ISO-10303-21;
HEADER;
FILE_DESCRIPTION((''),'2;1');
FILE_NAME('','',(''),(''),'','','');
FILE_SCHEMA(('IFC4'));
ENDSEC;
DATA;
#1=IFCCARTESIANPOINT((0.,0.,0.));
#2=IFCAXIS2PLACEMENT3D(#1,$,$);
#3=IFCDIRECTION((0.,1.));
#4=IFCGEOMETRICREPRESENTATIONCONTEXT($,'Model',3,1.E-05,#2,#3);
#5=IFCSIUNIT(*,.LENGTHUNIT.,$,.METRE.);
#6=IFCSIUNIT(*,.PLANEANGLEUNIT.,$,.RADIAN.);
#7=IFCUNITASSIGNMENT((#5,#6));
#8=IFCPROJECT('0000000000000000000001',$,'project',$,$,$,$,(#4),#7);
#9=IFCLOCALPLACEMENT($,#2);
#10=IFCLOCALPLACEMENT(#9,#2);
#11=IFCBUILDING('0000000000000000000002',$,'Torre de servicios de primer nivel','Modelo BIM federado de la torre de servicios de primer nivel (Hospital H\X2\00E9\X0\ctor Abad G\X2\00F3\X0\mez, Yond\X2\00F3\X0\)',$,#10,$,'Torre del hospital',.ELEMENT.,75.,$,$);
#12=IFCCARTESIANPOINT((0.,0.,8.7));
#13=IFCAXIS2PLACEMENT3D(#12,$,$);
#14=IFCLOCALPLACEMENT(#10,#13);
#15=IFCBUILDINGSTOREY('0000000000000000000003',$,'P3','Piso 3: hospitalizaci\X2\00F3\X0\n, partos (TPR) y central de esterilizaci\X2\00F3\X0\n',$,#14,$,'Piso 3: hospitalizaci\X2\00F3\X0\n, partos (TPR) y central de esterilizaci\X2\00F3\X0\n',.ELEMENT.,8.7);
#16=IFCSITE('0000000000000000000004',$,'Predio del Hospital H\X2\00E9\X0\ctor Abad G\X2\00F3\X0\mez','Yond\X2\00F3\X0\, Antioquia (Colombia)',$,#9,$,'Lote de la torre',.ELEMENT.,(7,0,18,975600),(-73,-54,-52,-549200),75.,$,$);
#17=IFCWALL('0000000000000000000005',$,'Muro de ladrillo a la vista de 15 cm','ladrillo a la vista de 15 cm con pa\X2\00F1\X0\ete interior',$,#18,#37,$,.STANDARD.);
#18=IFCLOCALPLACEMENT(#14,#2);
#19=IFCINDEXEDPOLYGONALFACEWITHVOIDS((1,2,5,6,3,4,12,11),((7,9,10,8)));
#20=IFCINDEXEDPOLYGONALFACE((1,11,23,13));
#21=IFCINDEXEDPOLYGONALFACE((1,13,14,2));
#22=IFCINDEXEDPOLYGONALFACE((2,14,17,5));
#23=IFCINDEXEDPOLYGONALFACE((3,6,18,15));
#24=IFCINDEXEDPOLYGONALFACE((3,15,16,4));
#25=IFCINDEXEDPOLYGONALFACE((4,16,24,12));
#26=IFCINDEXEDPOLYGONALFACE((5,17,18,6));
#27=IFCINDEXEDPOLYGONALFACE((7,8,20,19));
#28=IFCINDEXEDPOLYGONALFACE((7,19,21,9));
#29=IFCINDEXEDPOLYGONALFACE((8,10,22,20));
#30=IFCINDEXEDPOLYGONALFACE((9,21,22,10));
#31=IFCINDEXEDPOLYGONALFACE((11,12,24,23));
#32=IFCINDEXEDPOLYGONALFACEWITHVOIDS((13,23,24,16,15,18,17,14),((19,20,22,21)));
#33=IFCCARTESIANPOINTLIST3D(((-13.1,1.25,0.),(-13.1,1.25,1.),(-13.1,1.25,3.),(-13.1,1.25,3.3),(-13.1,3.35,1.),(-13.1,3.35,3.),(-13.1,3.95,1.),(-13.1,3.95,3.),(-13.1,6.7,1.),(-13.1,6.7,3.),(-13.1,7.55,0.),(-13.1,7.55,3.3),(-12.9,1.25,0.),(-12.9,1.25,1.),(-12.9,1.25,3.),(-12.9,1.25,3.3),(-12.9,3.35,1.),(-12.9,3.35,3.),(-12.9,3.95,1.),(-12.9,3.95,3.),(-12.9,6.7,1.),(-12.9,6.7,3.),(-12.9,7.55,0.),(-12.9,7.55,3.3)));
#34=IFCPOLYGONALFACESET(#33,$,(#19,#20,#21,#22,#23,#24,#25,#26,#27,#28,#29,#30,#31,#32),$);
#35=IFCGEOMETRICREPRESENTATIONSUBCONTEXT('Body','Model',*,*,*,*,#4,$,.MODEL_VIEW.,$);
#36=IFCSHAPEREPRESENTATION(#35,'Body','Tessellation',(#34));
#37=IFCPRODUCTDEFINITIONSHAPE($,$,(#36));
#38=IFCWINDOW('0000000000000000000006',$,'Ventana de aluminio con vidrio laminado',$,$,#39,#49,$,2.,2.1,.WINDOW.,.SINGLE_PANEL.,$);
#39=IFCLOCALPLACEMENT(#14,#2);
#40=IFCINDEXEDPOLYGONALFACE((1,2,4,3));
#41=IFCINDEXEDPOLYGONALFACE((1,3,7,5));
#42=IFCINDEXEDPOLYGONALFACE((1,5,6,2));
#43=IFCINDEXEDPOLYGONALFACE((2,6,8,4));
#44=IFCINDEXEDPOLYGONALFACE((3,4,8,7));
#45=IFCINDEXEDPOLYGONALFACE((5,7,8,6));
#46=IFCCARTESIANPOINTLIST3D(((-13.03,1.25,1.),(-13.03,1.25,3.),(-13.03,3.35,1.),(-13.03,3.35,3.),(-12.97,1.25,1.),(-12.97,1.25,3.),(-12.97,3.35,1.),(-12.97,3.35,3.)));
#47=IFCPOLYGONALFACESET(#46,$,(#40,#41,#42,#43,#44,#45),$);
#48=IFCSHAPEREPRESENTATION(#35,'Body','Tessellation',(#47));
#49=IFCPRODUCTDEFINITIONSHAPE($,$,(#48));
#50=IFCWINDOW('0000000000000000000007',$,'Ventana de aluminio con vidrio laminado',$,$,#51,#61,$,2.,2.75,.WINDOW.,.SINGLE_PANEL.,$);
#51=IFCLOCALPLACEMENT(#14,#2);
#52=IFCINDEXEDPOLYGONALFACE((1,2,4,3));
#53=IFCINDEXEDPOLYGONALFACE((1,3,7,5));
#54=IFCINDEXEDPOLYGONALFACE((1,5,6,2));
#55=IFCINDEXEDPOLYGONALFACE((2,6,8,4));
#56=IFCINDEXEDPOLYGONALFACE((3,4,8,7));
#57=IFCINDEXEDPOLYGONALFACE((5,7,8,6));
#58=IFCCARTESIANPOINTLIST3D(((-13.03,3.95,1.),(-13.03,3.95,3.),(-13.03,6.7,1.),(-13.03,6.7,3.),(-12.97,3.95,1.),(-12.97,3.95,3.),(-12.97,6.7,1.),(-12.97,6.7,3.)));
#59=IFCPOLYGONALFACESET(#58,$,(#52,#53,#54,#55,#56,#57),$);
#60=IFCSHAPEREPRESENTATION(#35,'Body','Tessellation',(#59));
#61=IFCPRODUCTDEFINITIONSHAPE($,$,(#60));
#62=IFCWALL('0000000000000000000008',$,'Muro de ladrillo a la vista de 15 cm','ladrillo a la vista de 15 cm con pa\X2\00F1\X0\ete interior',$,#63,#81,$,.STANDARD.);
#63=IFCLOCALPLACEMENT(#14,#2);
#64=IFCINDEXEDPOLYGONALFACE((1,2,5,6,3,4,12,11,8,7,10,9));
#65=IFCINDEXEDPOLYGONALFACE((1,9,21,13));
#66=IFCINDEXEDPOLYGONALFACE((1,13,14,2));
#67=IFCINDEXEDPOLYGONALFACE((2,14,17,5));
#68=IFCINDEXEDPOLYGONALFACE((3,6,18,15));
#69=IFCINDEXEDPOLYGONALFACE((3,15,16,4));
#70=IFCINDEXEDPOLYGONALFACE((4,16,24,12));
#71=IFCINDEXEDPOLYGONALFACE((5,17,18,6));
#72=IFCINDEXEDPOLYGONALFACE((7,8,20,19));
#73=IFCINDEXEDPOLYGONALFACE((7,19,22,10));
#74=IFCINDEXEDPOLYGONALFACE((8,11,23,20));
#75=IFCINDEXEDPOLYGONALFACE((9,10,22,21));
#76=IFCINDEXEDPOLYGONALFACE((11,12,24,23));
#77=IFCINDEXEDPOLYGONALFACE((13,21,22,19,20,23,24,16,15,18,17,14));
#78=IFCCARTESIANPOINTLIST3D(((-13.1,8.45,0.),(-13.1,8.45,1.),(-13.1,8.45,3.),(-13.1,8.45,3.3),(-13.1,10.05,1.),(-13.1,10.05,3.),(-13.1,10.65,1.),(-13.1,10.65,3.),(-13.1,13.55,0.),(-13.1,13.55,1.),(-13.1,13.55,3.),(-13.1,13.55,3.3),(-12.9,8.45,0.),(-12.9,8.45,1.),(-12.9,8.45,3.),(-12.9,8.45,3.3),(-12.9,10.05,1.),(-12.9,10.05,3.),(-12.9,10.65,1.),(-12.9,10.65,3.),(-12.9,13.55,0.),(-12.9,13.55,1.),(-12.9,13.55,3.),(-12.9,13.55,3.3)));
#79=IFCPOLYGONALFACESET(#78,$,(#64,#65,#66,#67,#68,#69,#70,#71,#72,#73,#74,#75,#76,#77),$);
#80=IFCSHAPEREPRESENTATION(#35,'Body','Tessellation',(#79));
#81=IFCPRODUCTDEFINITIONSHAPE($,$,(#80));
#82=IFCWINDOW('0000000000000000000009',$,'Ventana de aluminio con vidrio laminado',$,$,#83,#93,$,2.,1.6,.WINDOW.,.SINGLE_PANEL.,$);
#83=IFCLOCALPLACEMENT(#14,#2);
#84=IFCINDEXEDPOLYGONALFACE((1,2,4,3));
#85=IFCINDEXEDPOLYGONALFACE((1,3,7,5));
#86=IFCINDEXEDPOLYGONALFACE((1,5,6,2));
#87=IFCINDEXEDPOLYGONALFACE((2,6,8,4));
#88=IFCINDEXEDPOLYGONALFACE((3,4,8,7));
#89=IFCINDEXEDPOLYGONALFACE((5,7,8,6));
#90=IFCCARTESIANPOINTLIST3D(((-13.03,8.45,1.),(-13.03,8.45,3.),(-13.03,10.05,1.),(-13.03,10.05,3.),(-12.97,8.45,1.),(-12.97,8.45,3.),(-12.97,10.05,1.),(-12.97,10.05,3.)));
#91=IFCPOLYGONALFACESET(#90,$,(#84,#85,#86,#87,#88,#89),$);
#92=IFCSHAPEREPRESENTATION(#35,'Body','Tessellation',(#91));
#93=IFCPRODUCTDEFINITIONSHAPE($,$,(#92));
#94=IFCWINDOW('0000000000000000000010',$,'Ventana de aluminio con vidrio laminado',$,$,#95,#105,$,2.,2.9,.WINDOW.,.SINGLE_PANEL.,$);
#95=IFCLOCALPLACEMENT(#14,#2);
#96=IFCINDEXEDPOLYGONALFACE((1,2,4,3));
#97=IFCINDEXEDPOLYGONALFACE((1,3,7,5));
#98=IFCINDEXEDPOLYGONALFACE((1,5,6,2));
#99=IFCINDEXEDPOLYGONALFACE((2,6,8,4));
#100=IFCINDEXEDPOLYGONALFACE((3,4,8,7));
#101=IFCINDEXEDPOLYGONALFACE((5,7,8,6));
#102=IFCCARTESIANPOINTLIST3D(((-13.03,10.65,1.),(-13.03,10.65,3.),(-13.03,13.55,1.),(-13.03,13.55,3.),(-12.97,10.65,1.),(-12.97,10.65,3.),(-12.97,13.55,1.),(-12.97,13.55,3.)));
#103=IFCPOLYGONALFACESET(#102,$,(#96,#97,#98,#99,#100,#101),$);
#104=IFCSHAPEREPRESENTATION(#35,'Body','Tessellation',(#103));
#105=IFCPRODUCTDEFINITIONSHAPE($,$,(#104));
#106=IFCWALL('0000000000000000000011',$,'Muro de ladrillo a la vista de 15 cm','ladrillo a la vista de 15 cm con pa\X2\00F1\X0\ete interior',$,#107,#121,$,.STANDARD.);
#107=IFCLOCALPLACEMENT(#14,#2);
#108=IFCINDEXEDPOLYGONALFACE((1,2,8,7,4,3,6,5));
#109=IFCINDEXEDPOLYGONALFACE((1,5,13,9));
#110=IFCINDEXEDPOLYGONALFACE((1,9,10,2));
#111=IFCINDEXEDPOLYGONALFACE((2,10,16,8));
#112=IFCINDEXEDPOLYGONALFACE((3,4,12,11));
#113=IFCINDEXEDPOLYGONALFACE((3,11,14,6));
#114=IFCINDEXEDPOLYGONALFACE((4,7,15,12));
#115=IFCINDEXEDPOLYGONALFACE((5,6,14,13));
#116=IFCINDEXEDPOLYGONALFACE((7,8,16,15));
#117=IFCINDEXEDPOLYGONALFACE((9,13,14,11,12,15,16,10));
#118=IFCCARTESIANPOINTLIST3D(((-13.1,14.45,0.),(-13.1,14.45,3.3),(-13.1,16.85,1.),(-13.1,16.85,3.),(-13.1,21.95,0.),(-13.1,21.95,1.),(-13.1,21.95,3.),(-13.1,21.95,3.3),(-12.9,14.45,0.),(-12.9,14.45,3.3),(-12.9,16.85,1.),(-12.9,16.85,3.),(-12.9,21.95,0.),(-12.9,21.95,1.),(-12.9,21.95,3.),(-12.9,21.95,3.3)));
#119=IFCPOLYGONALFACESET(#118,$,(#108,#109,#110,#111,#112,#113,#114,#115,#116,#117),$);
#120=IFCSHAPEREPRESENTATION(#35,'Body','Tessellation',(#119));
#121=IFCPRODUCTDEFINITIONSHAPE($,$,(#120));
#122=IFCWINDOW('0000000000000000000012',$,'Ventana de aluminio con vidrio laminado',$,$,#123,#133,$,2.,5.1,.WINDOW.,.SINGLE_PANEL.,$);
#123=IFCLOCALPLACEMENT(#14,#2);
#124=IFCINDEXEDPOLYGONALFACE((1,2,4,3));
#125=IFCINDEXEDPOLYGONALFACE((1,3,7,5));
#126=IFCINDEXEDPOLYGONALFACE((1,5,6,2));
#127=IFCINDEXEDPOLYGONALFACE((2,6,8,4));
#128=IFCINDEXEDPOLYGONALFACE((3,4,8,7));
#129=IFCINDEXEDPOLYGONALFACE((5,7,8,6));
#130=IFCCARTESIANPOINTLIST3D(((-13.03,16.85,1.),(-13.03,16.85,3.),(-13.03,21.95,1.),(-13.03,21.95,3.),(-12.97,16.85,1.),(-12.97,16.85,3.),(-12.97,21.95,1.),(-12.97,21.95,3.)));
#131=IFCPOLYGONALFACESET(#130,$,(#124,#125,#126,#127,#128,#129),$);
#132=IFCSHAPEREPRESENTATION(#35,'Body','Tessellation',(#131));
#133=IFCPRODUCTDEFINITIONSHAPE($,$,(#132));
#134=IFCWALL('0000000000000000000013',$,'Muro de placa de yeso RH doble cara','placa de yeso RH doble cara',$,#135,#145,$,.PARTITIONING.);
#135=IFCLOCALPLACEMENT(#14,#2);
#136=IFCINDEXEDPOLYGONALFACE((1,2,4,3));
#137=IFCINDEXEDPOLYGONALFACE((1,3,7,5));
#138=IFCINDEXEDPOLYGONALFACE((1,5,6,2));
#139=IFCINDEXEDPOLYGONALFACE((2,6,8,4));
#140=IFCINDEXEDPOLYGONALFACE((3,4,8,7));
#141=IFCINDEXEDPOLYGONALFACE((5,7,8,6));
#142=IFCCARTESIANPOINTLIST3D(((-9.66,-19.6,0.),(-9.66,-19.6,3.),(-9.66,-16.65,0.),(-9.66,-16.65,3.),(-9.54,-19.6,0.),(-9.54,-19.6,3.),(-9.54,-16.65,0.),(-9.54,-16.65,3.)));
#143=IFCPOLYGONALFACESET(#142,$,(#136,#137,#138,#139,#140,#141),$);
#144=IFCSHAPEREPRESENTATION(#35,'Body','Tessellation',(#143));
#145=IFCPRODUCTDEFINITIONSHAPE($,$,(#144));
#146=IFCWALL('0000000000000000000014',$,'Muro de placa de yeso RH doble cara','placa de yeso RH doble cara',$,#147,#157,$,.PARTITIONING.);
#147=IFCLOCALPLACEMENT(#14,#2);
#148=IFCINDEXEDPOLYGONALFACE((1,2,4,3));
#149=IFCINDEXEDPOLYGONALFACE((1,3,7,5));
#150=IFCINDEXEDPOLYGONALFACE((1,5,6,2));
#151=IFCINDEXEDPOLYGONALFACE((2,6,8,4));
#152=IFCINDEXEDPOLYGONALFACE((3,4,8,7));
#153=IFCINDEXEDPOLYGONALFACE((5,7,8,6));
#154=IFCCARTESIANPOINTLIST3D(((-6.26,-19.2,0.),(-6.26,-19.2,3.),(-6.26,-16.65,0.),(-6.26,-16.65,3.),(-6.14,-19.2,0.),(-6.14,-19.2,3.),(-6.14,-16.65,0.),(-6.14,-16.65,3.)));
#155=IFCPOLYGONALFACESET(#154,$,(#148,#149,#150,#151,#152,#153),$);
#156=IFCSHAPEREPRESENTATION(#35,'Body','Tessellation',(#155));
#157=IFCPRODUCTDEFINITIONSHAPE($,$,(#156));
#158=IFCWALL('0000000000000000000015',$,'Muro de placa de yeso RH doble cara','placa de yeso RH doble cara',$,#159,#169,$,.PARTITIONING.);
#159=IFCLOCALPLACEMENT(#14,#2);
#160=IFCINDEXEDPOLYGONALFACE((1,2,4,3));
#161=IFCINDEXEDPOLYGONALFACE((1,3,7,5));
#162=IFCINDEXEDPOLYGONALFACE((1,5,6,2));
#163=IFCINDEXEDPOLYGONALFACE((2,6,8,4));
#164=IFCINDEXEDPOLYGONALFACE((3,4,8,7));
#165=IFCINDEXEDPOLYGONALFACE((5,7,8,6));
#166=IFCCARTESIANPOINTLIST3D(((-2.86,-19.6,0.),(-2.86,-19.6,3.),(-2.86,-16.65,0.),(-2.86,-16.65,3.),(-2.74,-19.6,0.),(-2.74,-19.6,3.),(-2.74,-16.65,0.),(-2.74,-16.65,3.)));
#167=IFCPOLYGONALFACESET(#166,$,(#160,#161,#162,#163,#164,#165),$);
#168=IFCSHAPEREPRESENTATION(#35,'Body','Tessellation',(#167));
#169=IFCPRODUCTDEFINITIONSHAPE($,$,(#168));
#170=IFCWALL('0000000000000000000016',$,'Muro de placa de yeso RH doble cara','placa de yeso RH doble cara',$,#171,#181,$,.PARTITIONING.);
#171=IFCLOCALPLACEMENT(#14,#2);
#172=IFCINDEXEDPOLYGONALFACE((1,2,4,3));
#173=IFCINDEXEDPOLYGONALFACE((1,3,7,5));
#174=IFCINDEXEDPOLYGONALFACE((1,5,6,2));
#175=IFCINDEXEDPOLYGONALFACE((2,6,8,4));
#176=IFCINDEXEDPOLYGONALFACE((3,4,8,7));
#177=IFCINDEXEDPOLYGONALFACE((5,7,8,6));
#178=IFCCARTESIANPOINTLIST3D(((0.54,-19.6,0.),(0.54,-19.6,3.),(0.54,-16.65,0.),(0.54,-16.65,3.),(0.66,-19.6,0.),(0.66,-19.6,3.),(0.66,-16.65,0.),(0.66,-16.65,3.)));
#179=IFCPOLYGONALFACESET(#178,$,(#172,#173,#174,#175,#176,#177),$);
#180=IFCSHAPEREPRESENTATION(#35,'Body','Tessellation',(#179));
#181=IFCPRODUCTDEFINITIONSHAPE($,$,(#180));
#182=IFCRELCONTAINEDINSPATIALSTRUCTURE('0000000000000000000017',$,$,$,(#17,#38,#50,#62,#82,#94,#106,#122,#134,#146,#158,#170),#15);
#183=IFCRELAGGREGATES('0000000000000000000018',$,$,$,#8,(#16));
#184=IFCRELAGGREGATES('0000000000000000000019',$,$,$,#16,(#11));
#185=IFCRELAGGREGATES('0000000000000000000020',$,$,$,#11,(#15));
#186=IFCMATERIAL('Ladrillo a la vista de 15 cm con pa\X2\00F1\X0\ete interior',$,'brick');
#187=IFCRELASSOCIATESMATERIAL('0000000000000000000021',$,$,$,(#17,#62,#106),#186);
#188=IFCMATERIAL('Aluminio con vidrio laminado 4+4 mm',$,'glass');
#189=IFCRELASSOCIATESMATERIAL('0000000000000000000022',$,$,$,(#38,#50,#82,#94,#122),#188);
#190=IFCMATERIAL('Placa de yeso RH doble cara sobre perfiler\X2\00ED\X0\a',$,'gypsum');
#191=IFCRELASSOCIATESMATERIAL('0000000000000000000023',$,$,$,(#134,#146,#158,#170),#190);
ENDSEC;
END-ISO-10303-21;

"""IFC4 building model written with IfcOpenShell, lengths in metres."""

from ifc_helpers import new_model, si_unit, direction, frame, origin, place, context, subcontext, project, spatial, rectangle, extrude, material, element, fill, save


model = new_model("IFC4")

# Units and contexts
model_context = context("Model", 3, precision=1e-05, world=origin(), true_north=direction((0.0, 1.0)))
body_context = subcontext(model_context, "Body", "Model", "MODEL_VIEW")
ifc_project = project(units=[si_unit("LENGTHUNIT", "METRE"), si_unit("PLANEANGLEUNIT", "RADIAN")], contexts=[model_context])

# Site, building, storey
site_placement = place(None, origin())
site = spatial("IfcSite", under=ifc_project, at=site_placement, Name="Predio del Hospital Héctor Abad Gómez", Description="Yondó, Antioquia (Colombia)", LongName="Lote de la torre", CompositionType="ELEMENT", RefLatitude=(7, 0, 18, 975600), RefLongitude=(-73, -54, -52, -549200), RefElevation=75.0)
building_placement = place(site_placement, origin())
building = spatial("IfcBuilding", under=site, at=building_placement, Name="Torre de servicios de primer nivel", Description="Modelo BIM federado de la torre de servicios de primer nivel (Hospital Héctor Abad Gómez, Yondó)", LongName="Torre del hospital", CompositionType="ELEMENT", ElevationOfRefHeight=75.0)
placement = place(building_placement, frame((0.0, 0.0, 8.7)))
storey = spatial("IfcBuildingStorey", under=building, at=placement, Name="P3", Description="Piso 3: hospitalización, partos (TPR) y central de esterilización", LongName="Piso 3: hospitalización, partos (TPR) y central de esterilización", CompositionType="ELEMENT", Elevation=8.7)

# Walls, openings, windows
ifc_material_1 = material(Name="Ladrillo a la vista de 15 cm con pañete interior", Category="brick")
wall_1 = element("IfcWall", 1, at=placement, inside=storey, material=ifc_material_1, Name="Muro de ladrillo a la vista de 15 cm", Description="ladrillo a la vista de 15 cm con pañete interior", PredefinedType="STANDARD", context=body_context, shape_type="SweptSolid", body=[
    extrude(rectangle(XDim=0.2, YDim=6.3), frame((-13.0, 4.4, 0.0)), (0.0, 0.0, 1.0), 3.3),
])
opening_1 = element("IfcOpeningElement", 2, at=placement, cuts=wall_1, PredefinedType="OPENING", context=body_context, shape_type="SweptSolid", body=[
    extrude(rectangle(XDim=0.3, YDim=2.1), frame((-13.0, 2.3, 1.0)), (0.0, 0.0, 1.0), 2.0),
])
opening_2 = element("IfcOpeningElement", 3, at=placement, cuts=wall_1, PredefinedType="OPENING", context=body_context, shape_type="SweptSolid", body=[
    extrude(rectangle(XDim=0.3, YDim=2.75), frame((-13.0, 5.325, 1.0)), (0.0, 0.0, 1.0), 2.0),
])
ifc_material_2 = material(Name="Aluminio con vidrio laminado 4+4 mm", Category="glass")
window_1 = element("IfcWindow", 4, at=placement, inside=storey, material=ifc_material_2, Name="Ventana de aluminio con vidrio laminado", OverallHeight=2.0, OverallWidth=2.1, PartitioningType="SINGLE_PANEL", PredefinedType="WINDOW", context=body_context, shape_type="SweptSolid", body=[
    extrude(rectangle(XDim=0.06, YDim=2.1), frame((-13.0, 2.3, 1.0)), (0.0, 0.0, 1.0), 2.0),
])
fill(opening_1, window_1)
window_2 = element("IfcWindow", 5, at=placement, inside=storey, material=ifc_material_2, Name="Ventana de aluminio con vidrio laminado", OverallHeight=2.0, OverallWidth=2.75, PartitioningType="SINGLE_PANEL", PredefinedType="WINDOW", context=body_context, shape_type="SweptSolid", body=[
    extrude(rectangle(XDim=0.06, YDim=2.75), frame((-13.0, 5.325, 1.0)), (0.0, 0.0, 1.0), 2.0),
])
fill(opening_2, window_2)
wall_2 = element("IfcWall", 6, at=placement, inside=storey, material=ifc_material_1, Name="Muro de ladrillo a la vista de 15 cm", Description="ladrillo a la vista de 15 cm con pañete interior", PredefinedType="STANDARD", context=body_context, shape_type="SweptSolid", body=[
    extrude(rectangle(XDim=0.2, YDim=5.1), frame((-13.0, 11.0, 0.0)), (0.0, 0.0, 1.0), 3.3),
])
opening_3 = element("IfcOpeningElement", 7, at=placement, cuts=wall_2, PredefinedType="OPENING", context=body_context, shape_type="SweptSolid", body=[
    extrude(rectangle(XDim=0.3, YDim=1.6), frame((-13.0, 9.25, 1.0)), (0.0, 0.0, 1.0), 2.0),
])
opening_4 = element("IfcOpeningElement", 8, at=placement, cuts=wall_2, PredefinedType="OPENING", context=body_context, shape_type="SweptSolid", body=[
    extrude(rectangle(XDim=0.3, YDim=2.9), frame((-13.0, 12.1, 1.0)), (0.0, 0.0, 1.0), 2.0),
])
window_3 = element("IfcWindow", 9, at=placement, inside=storey, material=ifc_material_2, Name="Ventana de aluminio con vidrio laminado", OverallHeight=2.0, OverallWidth=1.6, PartitioningType="SINGLE_PANEL", PredefinedType="WINDOW", context=body_context, shape_type="SweptSolid", body=[
    extrude(rectangle(XDim=0.06, YDim=1.6), frame((-13.0, 9.25, 1.0)), (0.0, 0.0, 1.0), 2.0),
])
fill(opening_3, window_3)
window_4 = element("IfcWindow", 10, at=placement, inside=storey, material=ifc_material_2, Name="Ventana de aluminio con vidrio laminado", OverallHeight=2.0, OverallWidth=2.9, PartitioningType="SINGLE_PANEL", PredefinedType="WINDOW", context=body_context, shape_type="SweptSolid", body=[
    extrude(rectangle(XDim=0.06, YDim=2.9), frame((-13.0, 12.1, 1.0)), (0.0, 0.0, 1.0), 2.0),
])
fill(opening_4, window_4)

# Wall, opening, window
wall_3 = element("IfcWall", 11, at=placement, inside=storey, material=ifc_material_1, Name="Muro de ladrillo a la vista de 15 cm", Description="ladrillo a la vista de 15 cm con pañete interior", PredefinedType="STANDARD", context=body_context, shape_type="SweptSolid", body=[
    extrude(rectangle(XDim=0.2, YDim=7.5), frame((-13.0, 18.2, 0.0)), (0.0, 0.0, 1.0), 3.3),
])
opening_5 = element("IfcOpeningElement", 12, at=placement, cuts=wall_3, PredefinedType="OPENING", context=body_context, shape_type="SweptSolid", body=[
    extrude(rectangle(XDim=0.3, YDim=5.1), frame((-13.0, 19.4, 1.0)), (0.0, 0.0, 1.0), 2.0),
])
window_5 = element("IfcWindow", 13, at=placement, inside=storey, material=ifc_material_2, Name="Ventana de aluminio con vidrio laminado", OverallHeight=2.0, OverallWidth=5.1, PartitioningType="SINGLE_PANEL", PredefinedType="WINDOW", context=body_context, shape_type="SweptSolid", body=[
    extrude(rectangle(XDim=0.06, YDim=5.1), frame((-13.0, 19.4, 1.0)), (0.0, 0.0, 1.0), 2.0),
])
fill(opening_5, window_5)

# Walls
ifc_material_3 = material(Name="Placa de yeso RH doble cara sobre perfilería", Category="gypsum")
element("IfcWall", 14, at=placement, inside=storey, material=ifc_material_3, Name="Muro de placa de yeso RH doble cara", Description="placa de yeso RH doble cara", PredefinedType="PARTITIONING", context=body_context, shape_type="SweptSolid", body=[
    extrude(rectangle(XDim=0.12, YDim=2.95), frame((-9.6, -18.125, 0.0)), (0.0, 0.0, 1.0), 3.0),
])
element("IfcWall", 15, at=placement, inside=storey, material=ifc_material_3, Name="Muro de placa de yeso RH doble cara", Description="placa de yeso RH doble cara", PredefinedType="PARTITIONING", context=body_context, shape_type="SweptSolid", body=[
    extrude(rectangle(XDim=0.12, YDim=2.55), frame((-6.2, -17.925, 0.0)), (0.0, 0.0, 1.0), 3.0),
])
element("IfcWall", 16, at=placement, inside=storey, material=ifc_material_3, Name="Muro de placa de yeso RH doble cara", Description="placa de yeso RH doble cara", PredefinedType="PARTITIONING", context=body_context, shape_type="SweptSolid", body=[
    extrude(rectangle(XDim=0.12, YDim=2.95), frame((-2.8, -18.125, 0.0)), (0.0, 0.0, 1.0), 3.0),
])
element("IfcWall", 17, at=placement, inside=storey, material=ifc_material_3, Name="Muro de placa de yeso RH doble cara", Description="placa de yeso RH doble cara", PredefinedType="PARTITIONING", context=body_context, shape_type="SweptSolid", body=[
    extrude(rectangle(XDim=0.12, YDim=2.95), frame((0.6, -18.125, 0.0)), (0.0, 0.0, 1.0), 3.0),
])

save(model, "model.ifc")
